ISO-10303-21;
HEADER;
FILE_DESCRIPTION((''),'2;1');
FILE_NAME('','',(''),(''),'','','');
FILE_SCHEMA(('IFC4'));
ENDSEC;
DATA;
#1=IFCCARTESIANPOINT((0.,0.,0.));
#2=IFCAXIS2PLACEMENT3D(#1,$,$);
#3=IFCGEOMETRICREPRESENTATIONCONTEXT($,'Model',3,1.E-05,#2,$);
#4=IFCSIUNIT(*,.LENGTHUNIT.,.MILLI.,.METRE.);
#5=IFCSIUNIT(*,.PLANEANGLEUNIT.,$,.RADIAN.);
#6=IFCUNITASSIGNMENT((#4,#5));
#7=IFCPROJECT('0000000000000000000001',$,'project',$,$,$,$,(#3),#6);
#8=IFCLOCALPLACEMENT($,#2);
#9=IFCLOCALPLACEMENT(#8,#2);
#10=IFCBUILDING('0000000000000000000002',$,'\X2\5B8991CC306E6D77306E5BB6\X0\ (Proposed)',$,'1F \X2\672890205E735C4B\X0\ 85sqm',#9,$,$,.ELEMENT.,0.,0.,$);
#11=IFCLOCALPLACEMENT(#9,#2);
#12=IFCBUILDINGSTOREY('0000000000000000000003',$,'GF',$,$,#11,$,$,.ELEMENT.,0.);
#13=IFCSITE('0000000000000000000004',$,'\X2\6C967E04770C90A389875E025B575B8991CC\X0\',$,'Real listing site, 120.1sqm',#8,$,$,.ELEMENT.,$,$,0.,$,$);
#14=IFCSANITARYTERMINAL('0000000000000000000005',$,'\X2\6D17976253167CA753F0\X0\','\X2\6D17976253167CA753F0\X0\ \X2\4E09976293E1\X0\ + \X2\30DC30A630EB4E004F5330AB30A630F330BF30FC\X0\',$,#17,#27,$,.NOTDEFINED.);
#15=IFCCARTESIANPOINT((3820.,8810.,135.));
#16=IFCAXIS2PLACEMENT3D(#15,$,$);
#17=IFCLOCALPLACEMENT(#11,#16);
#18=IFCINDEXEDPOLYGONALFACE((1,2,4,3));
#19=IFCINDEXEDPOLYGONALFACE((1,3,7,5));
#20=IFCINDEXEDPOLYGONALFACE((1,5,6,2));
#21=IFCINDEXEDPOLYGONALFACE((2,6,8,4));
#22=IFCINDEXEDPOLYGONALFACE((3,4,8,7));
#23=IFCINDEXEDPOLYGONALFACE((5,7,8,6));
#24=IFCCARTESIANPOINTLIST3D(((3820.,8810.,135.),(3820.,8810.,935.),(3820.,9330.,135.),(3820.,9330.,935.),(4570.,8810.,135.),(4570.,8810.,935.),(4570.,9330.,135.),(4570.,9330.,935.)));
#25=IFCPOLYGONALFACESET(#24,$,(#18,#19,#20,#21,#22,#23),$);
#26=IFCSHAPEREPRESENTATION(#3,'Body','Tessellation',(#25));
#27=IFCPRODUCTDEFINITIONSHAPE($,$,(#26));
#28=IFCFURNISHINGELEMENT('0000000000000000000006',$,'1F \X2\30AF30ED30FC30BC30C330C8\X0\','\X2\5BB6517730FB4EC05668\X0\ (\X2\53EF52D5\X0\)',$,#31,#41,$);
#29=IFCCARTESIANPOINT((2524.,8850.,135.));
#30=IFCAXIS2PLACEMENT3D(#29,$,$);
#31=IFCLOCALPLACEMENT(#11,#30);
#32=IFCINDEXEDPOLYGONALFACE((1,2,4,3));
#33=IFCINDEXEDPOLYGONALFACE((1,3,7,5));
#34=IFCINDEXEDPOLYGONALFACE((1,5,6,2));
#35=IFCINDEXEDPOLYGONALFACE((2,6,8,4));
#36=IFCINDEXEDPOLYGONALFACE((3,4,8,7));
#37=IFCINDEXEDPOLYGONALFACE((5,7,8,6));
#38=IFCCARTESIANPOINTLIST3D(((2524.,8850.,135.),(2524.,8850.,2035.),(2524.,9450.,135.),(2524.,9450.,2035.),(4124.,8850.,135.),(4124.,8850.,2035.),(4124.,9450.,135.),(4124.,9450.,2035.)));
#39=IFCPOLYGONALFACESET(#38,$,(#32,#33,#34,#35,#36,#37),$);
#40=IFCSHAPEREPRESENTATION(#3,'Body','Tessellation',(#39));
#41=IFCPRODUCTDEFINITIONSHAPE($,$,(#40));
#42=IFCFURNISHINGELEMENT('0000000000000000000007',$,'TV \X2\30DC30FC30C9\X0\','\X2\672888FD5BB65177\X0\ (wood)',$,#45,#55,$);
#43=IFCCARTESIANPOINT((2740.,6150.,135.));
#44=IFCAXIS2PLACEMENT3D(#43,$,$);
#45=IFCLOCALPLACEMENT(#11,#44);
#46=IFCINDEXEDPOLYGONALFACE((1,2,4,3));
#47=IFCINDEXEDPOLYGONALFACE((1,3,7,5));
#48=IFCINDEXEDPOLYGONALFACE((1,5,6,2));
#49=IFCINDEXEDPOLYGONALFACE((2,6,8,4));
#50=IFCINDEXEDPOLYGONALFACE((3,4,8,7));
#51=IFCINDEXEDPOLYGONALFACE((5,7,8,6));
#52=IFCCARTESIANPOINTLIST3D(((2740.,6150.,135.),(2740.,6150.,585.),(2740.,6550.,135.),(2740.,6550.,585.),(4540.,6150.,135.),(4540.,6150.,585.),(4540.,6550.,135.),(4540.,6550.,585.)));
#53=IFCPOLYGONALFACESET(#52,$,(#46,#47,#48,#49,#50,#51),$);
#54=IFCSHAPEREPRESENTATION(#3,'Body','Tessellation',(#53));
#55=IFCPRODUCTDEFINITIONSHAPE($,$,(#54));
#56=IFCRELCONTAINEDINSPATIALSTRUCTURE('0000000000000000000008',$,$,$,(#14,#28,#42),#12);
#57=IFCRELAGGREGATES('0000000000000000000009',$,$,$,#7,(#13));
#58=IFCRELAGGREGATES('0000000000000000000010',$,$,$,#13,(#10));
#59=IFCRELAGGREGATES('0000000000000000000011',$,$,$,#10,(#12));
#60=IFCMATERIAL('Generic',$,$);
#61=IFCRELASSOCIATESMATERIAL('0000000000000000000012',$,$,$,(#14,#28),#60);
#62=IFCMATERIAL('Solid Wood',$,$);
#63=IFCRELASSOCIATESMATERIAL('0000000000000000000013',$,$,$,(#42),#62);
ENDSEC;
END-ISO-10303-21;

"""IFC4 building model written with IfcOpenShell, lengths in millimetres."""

from ifc_helpers import new_model, si_unit, frame, frame_2d, origin, place, context, project, spatial, rectangle, extrude, material, element, save


model = new_model("IFC4")

# Units and contexts
model_context = context("Model", 3, precision=1e-05, world=origin())
ifc_project = project(units=[si_unit("LENGTHUNIT", "METRE", prefix="MILLI"), si_unit("PLANEANGLEUNIT", "RADIAN")], contexts=[model_context])

# Site, building, storey
site_placement = place(None, origin())
site = spatial("IfcSite", under=ifc_project, at=site_placement, Name="沖縄県那覇市字安里", ObjectType="Real listing site, 120.1sqm", CompositionType="ELEMENT", RefElevation=0.0)
building_placement = place(site_placement, origin())
building = spatial("IfcBuilding", under=site, at=building_placement, Name="安里の海の家 (Proposed)", ObjectType="1F 木造平屋 85sqm", CompositionType="ELEMENT", ElevationOfRefHeight=0.0, ElevationOfTerrain=0.0)
storey_placement = place(building_placement, origin())
storey = spatial("IfcBuildingStorey", under=building, at=storey_placement, Name="GF", CompositionType="ELEMENT", Elevation=0.0)

# Shared definitions
ifc_material_1 = material(Name="Solid Wood")

# Shared definitions
ifc_material_2 = material(Name="Generic")

# Sanitary terminal
sanitary_terminal_1_placement = place(storey_placement, frame((3820.0, 8810.0, 135.0)))
element("IfcSanitaryTerminal", 1, at=sanitary_terminal_1_placement, inside=storey, material=ifc_material_2, Name="洗面化粧台", Description="洗面化粧台 三面鏡 + ボウル一体カウンター", PredefinedType="NOTDEFINED", context=model_context, shape_type="SweptSolid", body=[
    extrude(rectangle(XDim=750.0, YDim=520.0, at=frame_2d((375.0, 260.0))), frame((3820.0, 8810.0, 135.0)), (0.0, 0.0, 1.0), 800.0),
])

# Furnishing elements
furnishing_1_placement = place(storey_placement, frame((2524.0, 8850.0, 135.0)))
element("IfcFurnishingElement", 2, at=furnishing_1_placement, inside=storey, material=ifc_material_2, Name="1F クローゼット", Description="家具・什器 (可動)", context=model_context, shape_type="SweptSolid", body=[
    extrude(rectangle(XDim=1600.0, YDim=600.0, at=frame_2d((800.0, 300.0))), frame((2524.0, 8850.0, 135.0)), (0.0, 0.0, 1.0), 1900.0),
])
furnishing_2_placement = place(storey_placement, frame((2740.0, 6150.0, 135.0)))
element("IfcFurnishingElement", 3, at=furnishing_2_placement, inside=storey, material=ifc_material_1, Name="TV ボード", Description="木製家具 (wood)", context=model_context, shape_type="SweptSolid", body=[
    extrude(rectangle(XDim=1800.0, YDim=400.0, at=frame_2d((900.0, 200.0))), frame((2740.0, 6150.0, 135.0)), (0.0, 0.0, 1.0), 450.0),
])

save(model, "model.ifc")
